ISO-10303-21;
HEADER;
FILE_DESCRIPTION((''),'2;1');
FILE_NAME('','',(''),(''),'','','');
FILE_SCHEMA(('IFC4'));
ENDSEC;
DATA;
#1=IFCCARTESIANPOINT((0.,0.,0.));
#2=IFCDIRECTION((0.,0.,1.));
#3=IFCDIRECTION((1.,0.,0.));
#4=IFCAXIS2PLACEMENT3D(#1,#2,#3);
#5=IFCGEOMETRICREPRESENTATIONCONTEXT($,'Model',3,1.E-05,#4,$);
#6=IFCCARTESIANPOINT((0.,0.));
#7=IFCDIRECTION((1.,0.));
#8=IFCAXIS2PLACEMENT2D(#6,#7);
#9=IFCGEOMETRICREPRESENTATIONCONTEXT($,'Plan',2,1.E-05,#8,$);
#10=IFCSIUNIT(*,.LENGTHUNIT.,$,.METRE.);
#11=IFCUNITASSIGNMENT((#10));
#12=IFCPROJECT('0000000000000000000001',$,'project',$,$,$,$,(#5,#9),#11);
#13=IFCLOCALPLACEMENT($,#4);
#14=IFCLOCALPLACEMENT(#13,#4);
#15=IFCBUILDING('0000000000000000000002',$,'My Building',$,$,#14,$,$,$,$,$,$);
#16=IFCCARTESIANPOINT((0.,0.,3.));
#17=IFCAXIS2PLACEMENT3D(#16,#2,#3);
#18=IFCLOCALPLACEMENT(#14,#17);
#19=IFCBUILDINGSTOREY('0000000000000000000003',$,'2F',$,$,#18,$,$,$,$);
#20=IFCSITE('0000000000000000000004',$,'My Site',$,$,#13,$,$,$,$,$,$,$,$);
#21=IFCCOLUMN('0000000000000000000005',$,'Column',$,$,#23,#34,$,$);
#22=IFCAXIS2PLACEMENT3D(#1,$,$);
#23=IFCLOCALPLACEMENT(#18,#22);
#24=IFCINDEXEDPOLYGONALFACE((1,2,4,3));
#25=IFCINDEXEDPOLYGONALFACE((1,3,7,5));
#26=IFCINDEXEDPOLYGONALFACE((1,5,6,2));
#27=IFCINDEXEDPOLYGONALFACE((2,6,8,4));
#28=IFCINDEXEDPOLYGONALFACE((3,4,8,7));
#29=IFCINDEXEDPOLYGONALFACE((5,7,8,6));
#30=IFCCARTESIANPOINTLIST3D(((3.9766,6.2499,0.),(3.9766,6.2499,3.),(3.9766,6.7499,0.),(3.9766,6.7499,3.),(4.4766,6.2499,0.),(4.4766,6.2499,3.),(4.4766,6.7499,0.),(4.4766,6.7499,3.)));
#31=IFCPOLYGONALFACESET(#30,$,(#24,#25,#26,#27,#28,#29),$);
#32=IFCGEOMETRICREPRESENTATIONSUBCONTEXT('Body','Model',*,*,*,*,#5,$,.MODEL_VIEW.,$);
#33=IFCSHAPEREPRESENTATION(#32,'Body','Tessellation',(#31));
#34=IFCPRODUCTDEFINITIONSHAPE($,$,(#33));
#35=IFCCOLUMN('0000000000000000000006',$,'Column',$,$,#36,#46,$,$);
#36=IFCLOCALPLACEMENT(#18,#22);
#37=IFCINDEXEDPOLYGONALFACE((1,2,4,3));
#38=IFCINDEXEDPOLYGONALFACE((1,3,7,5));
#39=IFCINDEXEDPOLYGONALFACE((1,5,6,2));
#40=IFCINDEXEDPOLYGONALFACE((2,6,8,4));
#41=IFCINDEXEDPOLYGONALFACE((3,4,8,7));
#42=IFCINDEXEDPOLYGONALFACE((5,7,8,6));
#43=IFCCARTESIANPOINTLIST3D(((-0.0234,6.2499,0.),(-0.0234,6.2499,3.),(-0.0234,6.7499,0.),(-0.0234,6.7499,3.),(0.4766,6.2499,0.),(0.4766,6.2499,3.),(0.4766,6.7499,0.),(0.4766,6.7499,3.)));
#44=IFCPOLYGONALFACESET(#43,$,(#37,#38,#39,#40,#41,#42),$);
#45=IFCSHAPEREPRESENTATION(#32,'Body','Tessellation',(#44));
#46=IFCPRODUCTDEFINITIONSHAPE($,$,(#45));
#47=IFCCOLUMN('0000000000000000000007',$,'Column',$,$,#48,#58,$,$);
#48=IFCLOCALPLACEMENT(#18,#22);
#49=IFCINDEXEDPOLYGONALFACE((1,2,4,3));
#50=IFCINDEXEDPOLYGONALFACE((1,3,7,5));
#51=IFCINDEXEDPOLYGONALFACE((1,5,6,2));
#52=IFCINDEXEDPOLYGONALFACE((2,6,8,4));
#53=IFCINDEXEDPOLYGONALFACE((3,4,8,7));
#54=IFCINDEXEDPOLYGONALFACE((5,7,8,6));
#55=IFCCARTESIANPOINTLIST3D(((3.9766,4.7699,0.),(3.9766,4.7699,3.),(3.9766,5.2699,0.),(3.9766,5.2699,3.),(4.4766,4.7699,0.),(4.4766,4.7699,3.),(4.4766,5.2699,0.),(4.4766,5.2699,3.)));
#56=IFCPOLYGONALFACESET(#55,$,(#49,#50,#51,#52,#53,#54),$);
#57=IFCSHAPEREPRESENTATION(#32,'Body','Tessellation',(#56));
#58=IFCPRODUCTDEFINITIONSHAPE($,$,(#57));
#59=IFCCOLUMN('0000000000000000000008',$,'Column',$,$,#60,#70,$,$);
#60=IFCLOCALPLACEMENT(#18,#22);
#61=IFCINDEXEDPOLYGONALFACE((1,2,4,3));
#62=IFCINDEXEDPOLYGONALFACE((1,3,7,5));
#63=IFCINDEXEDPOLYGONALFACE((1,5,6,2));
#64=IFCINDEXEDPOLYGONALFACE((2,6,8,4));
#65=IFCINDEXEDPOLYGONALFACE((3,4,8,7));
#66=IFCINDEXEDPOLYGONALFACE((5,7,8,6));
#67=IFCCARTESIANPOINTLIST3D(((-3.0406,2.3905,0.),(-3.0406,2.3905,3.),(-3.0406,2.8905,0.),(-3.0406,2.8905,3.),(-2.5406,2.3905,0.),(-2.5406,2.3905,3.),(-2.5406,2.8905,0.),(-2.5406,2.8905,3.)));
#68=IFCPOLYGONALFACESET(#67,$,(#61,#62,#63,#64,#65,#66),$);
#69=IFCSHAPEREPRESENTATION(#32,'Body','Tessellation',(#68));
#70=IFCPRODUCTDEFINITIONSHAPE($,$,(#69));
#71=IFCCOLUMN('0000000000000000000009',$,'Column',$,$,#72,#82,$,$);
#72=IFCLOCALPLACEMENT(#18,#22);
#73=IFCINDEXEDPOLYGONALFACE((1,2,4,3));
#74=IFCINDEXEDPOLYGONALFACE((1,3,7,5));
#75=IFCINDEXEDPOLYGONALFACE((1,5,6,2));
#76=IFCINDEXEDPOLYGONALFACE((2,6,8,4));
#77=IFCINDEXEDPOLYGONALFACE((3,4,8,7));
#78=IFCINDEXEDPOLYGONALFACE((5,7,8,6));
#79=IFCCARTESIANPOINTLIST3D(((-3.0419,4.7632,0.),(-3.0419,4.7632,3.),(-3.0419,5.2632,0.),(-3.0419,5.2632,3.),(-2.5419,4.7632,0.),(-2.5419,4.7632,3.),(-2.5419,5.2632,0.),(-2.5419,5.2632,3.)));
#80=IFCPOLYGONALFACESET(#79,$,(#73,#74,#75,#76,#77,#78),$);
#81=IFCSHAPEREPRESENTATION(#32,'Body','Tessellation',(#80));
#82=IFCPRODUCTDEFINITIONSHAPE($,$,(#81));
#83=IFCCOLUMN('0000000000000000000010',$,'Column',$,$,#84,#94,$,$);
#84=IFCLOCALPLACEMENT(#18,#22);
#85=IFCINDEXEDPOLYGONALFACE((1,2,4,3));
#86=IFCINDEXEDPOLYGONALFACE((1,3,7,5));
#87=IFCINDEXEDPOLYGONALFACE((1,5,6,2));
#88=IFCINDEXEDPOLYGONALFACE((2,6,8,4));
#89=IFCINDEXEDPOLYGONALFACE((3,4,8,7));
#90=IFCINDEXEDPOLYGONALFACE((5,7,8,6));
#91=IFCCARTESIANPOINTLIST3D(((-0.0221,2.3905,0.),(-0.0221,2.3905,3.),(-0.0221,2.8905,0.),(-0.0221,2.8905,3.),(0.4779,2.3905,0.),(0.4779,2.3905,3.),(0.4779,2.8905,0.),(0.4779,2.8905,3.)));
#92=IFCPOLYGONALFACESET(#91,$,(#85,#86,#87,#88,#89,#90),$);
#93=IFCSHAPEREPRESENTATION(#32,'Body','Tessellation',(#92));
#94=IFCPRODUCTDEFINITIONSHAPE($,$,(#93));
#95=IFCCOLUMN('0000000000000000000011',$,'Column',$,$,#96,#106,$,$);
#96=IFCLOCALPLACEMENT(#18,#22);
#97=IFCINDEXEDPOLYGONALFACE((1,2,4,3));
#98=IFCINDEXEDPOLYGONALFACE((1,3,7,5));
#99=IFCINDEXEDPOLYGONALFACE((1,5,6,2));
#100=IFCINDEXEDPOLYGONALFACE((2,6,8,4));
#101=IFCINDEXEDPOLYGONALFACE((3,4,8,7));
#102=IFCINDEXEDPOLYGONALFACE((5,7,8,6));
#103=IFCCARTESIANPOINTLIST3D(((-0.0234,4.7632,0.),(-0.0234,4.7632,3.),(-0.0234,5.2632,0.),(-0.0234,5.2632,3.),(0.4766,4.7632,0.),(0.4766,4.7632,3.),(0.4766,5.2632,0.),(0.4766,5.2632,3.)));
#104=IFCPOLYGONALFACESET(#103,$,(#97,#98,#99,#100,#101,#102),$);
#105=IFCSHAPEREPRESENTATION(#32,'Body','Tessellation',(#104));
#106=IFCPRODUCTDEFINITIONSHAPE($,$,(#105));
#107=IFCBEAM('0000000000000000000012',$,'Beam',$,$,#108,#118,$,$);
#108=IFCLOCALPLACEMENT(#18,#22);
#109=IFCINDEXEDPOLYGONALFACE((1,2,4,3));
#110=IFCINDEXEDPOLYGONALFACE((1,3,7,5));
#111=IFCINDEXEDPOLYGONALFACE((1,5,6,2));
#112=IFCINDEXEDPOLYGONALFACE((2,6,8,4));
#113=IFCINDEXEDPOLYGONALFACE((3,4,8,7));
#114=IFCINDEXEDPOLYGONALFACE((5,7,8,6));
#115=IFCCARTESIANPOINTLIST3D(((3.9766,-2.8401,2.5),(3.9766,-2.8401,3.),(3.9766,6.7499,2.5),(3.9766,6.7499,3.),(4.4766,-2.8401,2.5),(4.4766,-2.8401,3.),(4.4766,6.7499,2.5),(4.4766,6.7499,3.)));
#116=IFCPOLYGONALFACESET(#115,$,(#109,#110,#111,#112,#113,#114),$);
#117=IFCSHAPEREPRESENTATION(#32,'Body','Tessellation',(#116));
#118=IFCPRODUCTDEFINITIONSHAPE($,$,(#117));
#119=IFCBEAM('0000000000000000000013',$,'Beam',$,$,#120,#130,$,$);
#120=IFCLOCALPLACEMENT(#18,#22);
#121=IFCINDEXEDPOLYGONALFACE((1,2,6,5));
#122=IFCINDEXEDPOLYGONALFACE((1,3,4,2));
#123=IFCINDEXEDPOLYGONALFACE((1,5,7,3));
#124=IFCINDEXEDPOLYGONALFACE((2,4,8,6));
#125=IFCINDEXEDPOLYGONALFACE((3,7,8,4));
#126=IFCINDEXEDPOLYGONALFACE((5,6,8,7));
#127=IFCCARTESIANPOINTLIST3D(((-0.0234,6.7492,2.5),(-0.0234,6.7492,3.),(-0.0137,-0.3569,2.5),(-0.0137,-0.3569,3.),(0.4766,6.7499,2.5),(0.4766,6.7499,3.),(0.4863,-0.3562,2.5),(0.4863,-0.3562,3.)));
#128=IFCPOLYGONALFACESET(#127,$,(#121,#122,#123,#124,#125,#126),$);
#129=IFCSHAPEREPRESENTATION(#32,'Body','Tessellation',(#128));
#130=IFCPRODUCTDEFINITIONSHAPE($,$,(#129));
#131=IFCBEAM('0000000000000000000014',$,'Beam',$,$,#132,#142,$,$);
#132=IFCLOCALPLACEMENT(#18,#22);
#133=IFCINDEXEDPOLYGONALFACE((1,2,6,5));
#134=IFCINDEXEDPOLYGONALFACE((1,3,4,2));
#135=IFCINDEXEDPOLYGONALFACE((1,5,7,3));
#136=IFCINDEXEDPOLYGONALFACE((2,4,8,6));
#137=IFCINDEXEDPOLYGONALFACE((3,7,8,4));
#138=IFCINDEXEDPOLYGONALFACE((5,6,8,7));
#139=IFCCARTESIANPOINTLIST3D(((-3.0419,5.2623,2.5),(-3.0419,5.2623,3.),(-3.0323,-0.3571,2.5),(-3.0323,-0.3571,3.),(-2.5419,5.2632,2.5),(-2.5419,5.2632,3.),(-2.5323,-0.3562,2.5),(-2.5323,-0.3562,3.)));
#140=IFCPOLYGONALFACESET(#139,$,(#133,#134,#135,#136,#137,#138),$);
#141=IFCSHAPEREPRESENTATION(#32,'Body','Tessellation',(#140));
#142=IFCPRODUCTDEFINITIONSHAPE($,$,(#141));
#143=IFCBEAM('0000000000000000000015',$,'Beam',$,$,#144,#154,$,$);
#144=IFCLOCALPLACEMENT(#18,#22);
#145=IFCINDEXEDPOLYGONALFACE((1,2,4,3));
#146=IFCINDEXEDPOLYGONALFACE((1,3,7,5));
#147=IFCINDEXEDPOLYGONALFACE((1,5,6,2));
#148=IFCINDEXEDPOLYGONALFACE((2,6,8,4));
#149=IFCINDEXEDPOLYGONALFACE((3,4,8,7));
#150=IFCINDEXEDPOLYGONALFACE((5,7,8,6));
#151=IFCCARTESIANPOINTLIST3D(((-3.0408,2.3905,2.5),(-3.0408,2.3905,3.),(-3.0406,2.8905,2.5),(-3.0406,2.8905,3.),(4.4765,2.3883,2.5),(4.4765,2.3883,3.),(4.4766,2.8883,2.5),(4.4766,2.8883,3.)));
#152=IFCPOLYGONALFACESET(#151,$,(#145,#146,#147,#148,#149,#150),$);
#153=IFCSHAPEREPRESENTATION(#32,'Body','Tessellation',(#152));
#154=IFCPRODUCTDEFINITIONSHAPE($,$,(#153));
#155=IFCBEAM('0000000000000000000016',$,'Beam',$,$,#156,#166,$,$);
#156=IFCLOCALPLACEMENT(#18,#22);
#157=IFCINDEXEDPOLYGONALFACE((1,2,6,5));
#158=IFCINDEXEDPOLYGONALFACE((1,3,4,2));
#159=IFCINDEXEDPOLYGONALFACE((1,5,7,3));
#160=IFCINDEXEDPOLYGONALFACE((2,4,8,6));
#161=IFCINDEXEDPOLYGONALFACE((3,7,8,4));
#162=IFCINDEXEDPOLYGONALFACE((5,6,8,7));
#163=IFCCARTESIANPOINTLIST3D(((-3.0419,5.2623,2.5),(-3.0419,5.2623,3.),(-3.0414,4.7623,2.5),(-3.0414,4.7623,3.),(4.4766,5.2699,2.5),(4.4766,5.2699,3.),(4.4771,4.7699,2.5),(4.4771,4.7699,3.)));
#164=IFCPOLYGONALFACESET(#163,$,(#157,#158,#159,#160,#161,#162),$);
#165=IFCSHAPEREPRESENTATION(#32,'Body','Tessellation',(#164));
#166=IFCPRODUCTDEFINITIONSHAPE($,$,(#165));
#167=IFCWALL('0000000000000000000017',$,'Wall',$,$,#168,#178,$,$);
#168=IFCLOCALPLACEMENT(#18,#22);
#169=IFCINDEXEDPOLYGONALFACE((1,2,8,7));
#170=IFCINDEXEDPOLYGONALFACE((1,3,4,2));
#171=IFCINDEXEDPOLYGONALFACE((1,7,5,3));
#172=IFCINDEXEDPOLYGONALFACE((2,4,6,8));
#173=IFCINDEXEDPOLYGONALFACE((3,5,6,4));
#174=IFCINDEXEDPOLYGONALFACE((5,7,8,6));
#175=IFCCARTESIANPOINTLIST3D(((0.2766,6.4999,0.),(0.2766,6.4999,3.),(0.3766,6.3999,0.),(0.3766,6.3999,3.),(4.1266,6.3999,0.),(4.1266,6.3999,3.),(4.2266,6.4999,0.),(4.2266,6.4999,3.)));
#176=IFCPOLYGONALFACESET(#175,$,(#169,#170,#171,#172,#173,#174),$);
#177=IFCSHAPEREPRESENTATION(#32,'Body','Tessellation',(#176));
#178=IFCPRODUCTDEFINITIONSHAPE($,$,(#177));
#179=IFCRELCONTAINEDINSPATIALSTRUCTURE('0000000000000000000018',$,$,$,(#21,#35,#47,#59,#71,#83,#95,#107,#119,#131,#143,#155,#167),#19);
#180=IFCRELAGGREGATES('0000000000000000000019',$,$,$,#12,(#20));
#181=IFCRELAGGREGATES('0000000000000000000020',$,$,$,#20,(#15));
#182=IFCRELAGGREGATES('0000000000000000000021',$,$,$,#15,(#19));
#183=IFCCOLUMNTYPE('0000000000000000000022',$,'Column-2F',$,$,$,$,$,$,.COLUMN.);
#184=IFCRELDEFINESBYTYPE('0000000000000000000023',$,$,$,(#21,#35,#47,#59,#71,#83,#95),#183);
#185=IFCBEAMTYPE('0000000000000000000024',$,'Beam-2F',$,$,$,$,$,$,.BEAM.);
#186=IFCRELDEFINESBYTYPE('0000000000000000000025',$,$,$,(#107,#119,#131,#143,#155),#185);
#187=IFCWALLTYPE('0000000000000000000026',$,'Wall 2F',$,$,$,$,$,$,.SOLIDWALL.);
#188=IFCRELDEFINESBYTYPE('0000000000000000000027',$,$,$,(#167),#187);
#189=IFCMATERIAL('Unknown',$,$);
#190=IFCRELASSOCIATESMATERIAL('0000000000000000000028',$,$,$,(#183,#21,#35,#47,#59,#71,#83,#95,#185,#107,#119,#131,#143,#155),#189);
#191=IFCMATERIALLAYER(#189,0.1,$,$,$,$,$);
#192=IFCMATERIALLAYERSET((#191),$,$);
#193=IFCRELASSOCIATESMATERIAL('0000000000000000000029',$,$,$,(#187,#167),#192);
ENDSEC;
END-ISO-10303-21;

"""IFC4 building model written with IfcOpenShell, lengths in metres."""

from ifc_helpers import new_model, si_unit, frame, origin_with_axes, origin_2d_with_axis, place, context, subcontext, project, spatial, line, indexed_curve, rectangle, outline, extrude, material, layer, layer_set, layer_usage, material_profile, profile_set, profile_usage, type_object, element, save


model = new_model("IFC4")

# Units and contexts
model_context = context("Model", 3, precision=1e-05, world=origin_with_axes())
plan_context = context("Plan", 2, precision=1e-05, world=origin_2d_with_axis())
body_context_1 = subcontext(model_context, "Body", "Model", "MODEL_VIEW")
ifc_project = project(units=[si_unit("LENGTHUNIT", "METRE")], contexts=[model_context, plan_context])

# Site, building, storey
site_placement = place(None, origin_with_axes())
site = spatial("IfcSite", under=ifc_project, at=site_placement, Name="My Site")
building_placement = place(site_placement, origin_with_axes())
building = spatial("IfcBuilding", under=site, at=building_placement, Name="My Building")
storey_placement = place(building_placement, frame((0.0, 0.0, 3.0), z_axis=(0.0, 0.0, 1.0), x_axis=(1.0, 0.0, 0.0)))
storey = spatial("IfcBuildingStorey", under=building, at=storey_placement, Name="2F")

# Columns
ifc_material = material(Name="Unknown")
ifc_material_profile_1 = material_profile(ifc_material, rectangle(XDim=0.5, YDim=0.5))
ifc_profile_set_1 = profile_set([ifc_material_profile_1])
ifc_profile_usage_1 = profile_usage(ifc_profile_set_1, cardinal=7)
column_type = type_object("IfcColumnType", Name="Column-2F", PredefinedType="COLUMN", material=ifc_profile_set_1)
column_1_placement = place(storey_placement, frame((4.4766, 6.7499, 0.0), z_axis=(0.0, 0.0, 1.0), x_axis=(1.0, 0.0, 0.0)))
element("IfcColumn", 1, at=column_1_placement, inside=storey, type_object=column_type, material=ifc_profile_usage_1, Name="Column", context=body_context_1, shape_type="SweptSolid", body=[
    extrude(rectangle(XDim=0.5, YDim=0.5), frame((-0.25, -0.25, 0.0), z_axis=(0.0, 0.0, 1.0), x_axis=(1.0, 0.0, 0.0)), (0.0, 0.0, 1.0), 3.0),
])
ifc_profile_usage_2 = profile_usage(ifc_profile_set_1, cardinal=7)
column_2_placement = place(storey_placement, frame((0.4766, 6.7499, 0.0), z_axis=(0.0, 0.0, 1.0), x_axis=(1.0, 0.0, 0.0)))
element("IfcColumn", 2, at=column_2_placement, inside=storey, type_object=column_type, material=ifc_profile_usage_2, Name="Column", context=body_context_1, shape_type="SweptSolid", body=[
    extrude(rectangle(XDim=0.5, YDim=0.5), frame((-0.25, -0.25, 0.0), z_axis=(0.0, 0.0, 1.0), x_axis=(1.0, 0.0, 0.0)), (0.0, 0.0, 1.0), 3.0),
])
ifc_profile_usage_3 = profile_usage(ifc_profile_set_1, cardinal=7)
column_3_placement = place(storey_placement, frame((4.4766, 5.2699, 0.0), z_axis=(0.0, 0.0, 1.0), x_axis=(1.0, 0.0, 0.0)))
element("IfcColumn", 3, at=column_3_placement, inside=storey, type_object=column_type, material=ifc_profile_usage_3, Name="Column", context=body_context_1, shape_type="SweptSolid", body=[
    extrude(rectangle(XDim=0.5, YDim=0.5), frame((-0.25, -0.25, 0.0), z_axis=(0.0, 0.0, 1.0), x_axis=(1.0, 0.0, 0.0)), (0.0, 0.0, 1.0), 3.0),
])
ifc_profile_usage_4 = profile_usage(ifc_profile_set_1, cardinal=7)
column_4_placement = place(storey_placement, frame((-2.5406, 2.8905, 0.0), z_axis=(0.0, 0.0, 1.0), x_axis=(1.0, 0.0, 0.0)))
element("IfcColumn", 4, at=column_4_placement, inside=storey, type_object=column_type, material=ifc_profile_usage_4, Name="Column", context=body_context_1, shape_type="SweptSolid", body=[
    extrude(rectangle(XDim=0.5, YDim=0.5), frame((-0.25, -0.25, 0.0), z_axis=(0.0, 0.0, 1.0), x_axis=(1.0, 0.0, 0.0)), (0.0, 0.0, 1.0), 3.0),
])
ifc_profile_usage_5 = profile_usage(ifc_profile_set_1, cardinal=7)
column_5_placement = place(storey_placement, frame((-2.5419, 5.2632, 0.0), z_axis=(0.0, 0.0, 1.0), x_axis=(1.0, 0.0, 0.0)))
element("IfcColumn", 5, at=column_5_placement, inside=storey, type_object=column_type, material=ifc_profile_usage_5, Name="Column", context=body_context_1, shape_type="SweptSolid", body=[
    extrude(rectangle(XDim=0.5, YDim=0.5), frame((-0.25, -0.25, 0.0), z_axis=(0.0, 0.0, 1.0), x_axis=(1.0, 0.0, 0.0)), (0.0, 0.0, 1.0), 3.0),
])
ifc_profile_usage_6 = profile_usage(ifc_profile_set_1, cardinal=7)
column_6_placement = place(storey_placement, frame((0.4779, 2.8905, 0.0), z_axis=(0.0, 0.0, 1.0), x_axis=(1.0, 0.0, 0.0)))
element("IfcColumn", 6, at=column_6_placement, inside=storey, type_object=column_type, material=ifc_profile_usage_6, Name="Column", context=body_context_1, shape_type="SweptSolid", body=[
    extrude(rectangle(XDim=0.5, YDim=0.5), frame((-0.25, -0.25, 0.0), z_axis=(0.0, 0.0, 1.0), x_axis=(1.0, 0.0, 0.0)), (0.0, 0.0, 1.0), 3.0),
])
ifc_profile_usage_7 = profile_usage(ifc_profile_set_1, cardinal=7)
column_7_placement = place(storey_placement, frame((0.4766, 5.2632, 0.0), z_axis=(0.0, 0.0, 1.0), x_axis=(1.0, 0.0, 0.0)))
element("IfcColumn", 7, at=column_7_placement, inside=storey, type_object=column_type, material=ifc_profile_usage_7, Name="Column", context=body_context_1, shape_type="SweptSolid", body=[
    extrude(rectangle(XDim=0.5, YDim=0.5), frame((-0.25, -0.25, 0.0), z_axis=(0.0, 0.0, 1.0), x_axis=(1.0, 0.0, 0.0)), (0.0, 0.0, 1.0), 3.0),
])

# Beams
ifc_material_profile_2 = material_profile(ifc_material, rectangle(XDim=0.5, YDim=0.5))
ifc_profile_set_2 = profile_set([ifc_material_profile_2])
ifc_profile_usage_8 = profile_usage(ifc_profile_set_2, cardinal=7)
beam_type = type_object("IfcBeamType", Name="Beam-2F", PredefinedType="BEAM", material=ifc_profile_set_2)
beam_1_placement = place(storey_placement, frame((4.4766, 6.7499, 3.0), z_axis=(0.0, -1.0, 0.0), x_axis=(1.0, 0.0, 0.0)))
element("IfcBeam", 8, at=beam_1_placement, inside=storey, type_object=beam_type, material=ifc_profile_usage_8, Name="Beam", context=body_context_1, shape_type="SweptSolid", body=[
    extrude(rectangle(XDim=0.5, YDim=0.5), frame((-0.25, -0.25, 0.0), z_axis=(0.0, 0.0, 1.0), x_axis=(1.0, 0.0, 0.0)), (0.0, 0.0, 1.0), 9.59),
])
ifc_profile_usage_9 = profile_usage(ifc_profile_set_2, cardinal=7)
beam_2_placement = place(storey_placement, frame((0.4766, 6.7499, 3.0), z_axis=(0.00136, -0.999999, 0.0), x_axis=(0.999999, 0.00136, 0.0)))
element("IfcBeam", 9, at=beam_2_placement, inside=storey, type_object=beam_type, material=ifc_profile_usage_9, Name="Beam", context=body_context_1, shape_type="SweptSolid", body=[
    extrude(rectangle(XDim=0.5, YDim=0.5), frame((-0.25, -0.25, 0.0), z_axis=(0.0, 0.0, 1.0), x_axis=(1.0, 0.0, 0.0)), (0.0, 0.0, 1.0), 7.1061),
])
ifc_profile_usage_10 = profile_usage(ifc_profile_set_2, cardinal=7)
beam_3_placement = place(storey_placement, frame((-2.5419, 5.2632, 3.0), z_axis=(0.00172, -0.999999, 0.0), x_axis=(0.999999, 0.00172, 0.0)))
element("IfcBeam", 10, at=beam_3_placement, inside=storey, type_object=beam_type, material=ifc_profile_usage_10, Name="Beam", context=body_context_1, shape_type="SweptSolid", body=[
    extrude(rectangle(XDim=0.5, YDim=0.5), frame((-0.25, -0.25, 0.0), z_axis=(0.0, 0.0, 1.0), x_axis=(1.0, 0.0, 0.0)), (0.0, 0.0, 1.0), 5.6194),
])
ifc_profile_usage_11 = profile_usage(ifc_profile_set_2, cardinal=7)
beam_4_placement = place(storey_placement, frame((-3.0406, 2.8905, 3.0), z_axis=(1.0, -0.000286, 0.0), x_axis=(0.000286, 1.0, 0.0)))
element("IfcBeam", 11, at=beam_4_placement, inside=storey, type_object=beam_type, material=ifc_profile_usage_11, Name="Beam", context=body_context_1, shape_type="SweptSolid", body=[
    extrude(rectangle(XDim=0.5, YDim=0.5), frame((-0.25, -0.25, 0.0), z_axis=(0.0, 0.0, 1.0), x_axis=(1.0, 0.0, 0.0)), (0.0, 0.0, 1.0), 7.5172),
])
ifc_profile_usage_12 = profile_usage(ifc_profile_set_2, cardinal=7)
beam_5_placement = place(storey_placement, frame((-3.0419, 5.2623, 3.0), z_axis=(0.999999, 0.00101, 0.0), x_axis=(-0.00101, 0.999999, 0.0)))
element("IfcBeam", 12, at=beam_5_placement, inside=storey, type_object=beam_type, material=ifc_profile_usage_12, Name="Beam", context=body_context_1, shape_type="SweptSolid", body=[
    extrude(rectangle(XDim=0.5, YDim=0.5), frame((-0.25, -0.25, 0.0), z_axis=(0.0, 0.0, 1.0), x_axis=(1.0, 0.0, 0.0)), (0.0, 0.0, 1.0), 7.5185),
])

# Wall
ifc_layer = layer(ifc_material, 0.1)
ifc_layer_set = layer_set([ifc_layer])
ifc_layer_usage_1 = layer_usage(ifc_layer_set, "AXIS2", "POSITIVE", 0.0)
wall_type = type_object("IfcWallType", Name="Wall 2F", PredefinedType="SOLIDWALL", material=ifc_layer_set)
wall_1_placement = place(storey_placement, frame((4.2266, 6.4999, 0.0), z_axis=(0.0, 0.0, 1.0), x_axis=(-1.0, 0.0, 0.0)))
element("IfcWall", 13, at=wall_1_placement, inside=storey, type_object=wall_type, material=ifc_layer_usage_1, Name="Wall", context=body_context_1, shape_type="SweptSolid", body=[
    extrude(outline(indexed_curve([(0.0, 0.0), (0.1, 0.1), (3.85, 0.1), (3.95, 0.0)], segments=[line(1, 2, 3, 4, 1)])), origin_with_axes(), (0.0, 0.0, 1.0), 3.0),
])

save(model, "model.ifc")
